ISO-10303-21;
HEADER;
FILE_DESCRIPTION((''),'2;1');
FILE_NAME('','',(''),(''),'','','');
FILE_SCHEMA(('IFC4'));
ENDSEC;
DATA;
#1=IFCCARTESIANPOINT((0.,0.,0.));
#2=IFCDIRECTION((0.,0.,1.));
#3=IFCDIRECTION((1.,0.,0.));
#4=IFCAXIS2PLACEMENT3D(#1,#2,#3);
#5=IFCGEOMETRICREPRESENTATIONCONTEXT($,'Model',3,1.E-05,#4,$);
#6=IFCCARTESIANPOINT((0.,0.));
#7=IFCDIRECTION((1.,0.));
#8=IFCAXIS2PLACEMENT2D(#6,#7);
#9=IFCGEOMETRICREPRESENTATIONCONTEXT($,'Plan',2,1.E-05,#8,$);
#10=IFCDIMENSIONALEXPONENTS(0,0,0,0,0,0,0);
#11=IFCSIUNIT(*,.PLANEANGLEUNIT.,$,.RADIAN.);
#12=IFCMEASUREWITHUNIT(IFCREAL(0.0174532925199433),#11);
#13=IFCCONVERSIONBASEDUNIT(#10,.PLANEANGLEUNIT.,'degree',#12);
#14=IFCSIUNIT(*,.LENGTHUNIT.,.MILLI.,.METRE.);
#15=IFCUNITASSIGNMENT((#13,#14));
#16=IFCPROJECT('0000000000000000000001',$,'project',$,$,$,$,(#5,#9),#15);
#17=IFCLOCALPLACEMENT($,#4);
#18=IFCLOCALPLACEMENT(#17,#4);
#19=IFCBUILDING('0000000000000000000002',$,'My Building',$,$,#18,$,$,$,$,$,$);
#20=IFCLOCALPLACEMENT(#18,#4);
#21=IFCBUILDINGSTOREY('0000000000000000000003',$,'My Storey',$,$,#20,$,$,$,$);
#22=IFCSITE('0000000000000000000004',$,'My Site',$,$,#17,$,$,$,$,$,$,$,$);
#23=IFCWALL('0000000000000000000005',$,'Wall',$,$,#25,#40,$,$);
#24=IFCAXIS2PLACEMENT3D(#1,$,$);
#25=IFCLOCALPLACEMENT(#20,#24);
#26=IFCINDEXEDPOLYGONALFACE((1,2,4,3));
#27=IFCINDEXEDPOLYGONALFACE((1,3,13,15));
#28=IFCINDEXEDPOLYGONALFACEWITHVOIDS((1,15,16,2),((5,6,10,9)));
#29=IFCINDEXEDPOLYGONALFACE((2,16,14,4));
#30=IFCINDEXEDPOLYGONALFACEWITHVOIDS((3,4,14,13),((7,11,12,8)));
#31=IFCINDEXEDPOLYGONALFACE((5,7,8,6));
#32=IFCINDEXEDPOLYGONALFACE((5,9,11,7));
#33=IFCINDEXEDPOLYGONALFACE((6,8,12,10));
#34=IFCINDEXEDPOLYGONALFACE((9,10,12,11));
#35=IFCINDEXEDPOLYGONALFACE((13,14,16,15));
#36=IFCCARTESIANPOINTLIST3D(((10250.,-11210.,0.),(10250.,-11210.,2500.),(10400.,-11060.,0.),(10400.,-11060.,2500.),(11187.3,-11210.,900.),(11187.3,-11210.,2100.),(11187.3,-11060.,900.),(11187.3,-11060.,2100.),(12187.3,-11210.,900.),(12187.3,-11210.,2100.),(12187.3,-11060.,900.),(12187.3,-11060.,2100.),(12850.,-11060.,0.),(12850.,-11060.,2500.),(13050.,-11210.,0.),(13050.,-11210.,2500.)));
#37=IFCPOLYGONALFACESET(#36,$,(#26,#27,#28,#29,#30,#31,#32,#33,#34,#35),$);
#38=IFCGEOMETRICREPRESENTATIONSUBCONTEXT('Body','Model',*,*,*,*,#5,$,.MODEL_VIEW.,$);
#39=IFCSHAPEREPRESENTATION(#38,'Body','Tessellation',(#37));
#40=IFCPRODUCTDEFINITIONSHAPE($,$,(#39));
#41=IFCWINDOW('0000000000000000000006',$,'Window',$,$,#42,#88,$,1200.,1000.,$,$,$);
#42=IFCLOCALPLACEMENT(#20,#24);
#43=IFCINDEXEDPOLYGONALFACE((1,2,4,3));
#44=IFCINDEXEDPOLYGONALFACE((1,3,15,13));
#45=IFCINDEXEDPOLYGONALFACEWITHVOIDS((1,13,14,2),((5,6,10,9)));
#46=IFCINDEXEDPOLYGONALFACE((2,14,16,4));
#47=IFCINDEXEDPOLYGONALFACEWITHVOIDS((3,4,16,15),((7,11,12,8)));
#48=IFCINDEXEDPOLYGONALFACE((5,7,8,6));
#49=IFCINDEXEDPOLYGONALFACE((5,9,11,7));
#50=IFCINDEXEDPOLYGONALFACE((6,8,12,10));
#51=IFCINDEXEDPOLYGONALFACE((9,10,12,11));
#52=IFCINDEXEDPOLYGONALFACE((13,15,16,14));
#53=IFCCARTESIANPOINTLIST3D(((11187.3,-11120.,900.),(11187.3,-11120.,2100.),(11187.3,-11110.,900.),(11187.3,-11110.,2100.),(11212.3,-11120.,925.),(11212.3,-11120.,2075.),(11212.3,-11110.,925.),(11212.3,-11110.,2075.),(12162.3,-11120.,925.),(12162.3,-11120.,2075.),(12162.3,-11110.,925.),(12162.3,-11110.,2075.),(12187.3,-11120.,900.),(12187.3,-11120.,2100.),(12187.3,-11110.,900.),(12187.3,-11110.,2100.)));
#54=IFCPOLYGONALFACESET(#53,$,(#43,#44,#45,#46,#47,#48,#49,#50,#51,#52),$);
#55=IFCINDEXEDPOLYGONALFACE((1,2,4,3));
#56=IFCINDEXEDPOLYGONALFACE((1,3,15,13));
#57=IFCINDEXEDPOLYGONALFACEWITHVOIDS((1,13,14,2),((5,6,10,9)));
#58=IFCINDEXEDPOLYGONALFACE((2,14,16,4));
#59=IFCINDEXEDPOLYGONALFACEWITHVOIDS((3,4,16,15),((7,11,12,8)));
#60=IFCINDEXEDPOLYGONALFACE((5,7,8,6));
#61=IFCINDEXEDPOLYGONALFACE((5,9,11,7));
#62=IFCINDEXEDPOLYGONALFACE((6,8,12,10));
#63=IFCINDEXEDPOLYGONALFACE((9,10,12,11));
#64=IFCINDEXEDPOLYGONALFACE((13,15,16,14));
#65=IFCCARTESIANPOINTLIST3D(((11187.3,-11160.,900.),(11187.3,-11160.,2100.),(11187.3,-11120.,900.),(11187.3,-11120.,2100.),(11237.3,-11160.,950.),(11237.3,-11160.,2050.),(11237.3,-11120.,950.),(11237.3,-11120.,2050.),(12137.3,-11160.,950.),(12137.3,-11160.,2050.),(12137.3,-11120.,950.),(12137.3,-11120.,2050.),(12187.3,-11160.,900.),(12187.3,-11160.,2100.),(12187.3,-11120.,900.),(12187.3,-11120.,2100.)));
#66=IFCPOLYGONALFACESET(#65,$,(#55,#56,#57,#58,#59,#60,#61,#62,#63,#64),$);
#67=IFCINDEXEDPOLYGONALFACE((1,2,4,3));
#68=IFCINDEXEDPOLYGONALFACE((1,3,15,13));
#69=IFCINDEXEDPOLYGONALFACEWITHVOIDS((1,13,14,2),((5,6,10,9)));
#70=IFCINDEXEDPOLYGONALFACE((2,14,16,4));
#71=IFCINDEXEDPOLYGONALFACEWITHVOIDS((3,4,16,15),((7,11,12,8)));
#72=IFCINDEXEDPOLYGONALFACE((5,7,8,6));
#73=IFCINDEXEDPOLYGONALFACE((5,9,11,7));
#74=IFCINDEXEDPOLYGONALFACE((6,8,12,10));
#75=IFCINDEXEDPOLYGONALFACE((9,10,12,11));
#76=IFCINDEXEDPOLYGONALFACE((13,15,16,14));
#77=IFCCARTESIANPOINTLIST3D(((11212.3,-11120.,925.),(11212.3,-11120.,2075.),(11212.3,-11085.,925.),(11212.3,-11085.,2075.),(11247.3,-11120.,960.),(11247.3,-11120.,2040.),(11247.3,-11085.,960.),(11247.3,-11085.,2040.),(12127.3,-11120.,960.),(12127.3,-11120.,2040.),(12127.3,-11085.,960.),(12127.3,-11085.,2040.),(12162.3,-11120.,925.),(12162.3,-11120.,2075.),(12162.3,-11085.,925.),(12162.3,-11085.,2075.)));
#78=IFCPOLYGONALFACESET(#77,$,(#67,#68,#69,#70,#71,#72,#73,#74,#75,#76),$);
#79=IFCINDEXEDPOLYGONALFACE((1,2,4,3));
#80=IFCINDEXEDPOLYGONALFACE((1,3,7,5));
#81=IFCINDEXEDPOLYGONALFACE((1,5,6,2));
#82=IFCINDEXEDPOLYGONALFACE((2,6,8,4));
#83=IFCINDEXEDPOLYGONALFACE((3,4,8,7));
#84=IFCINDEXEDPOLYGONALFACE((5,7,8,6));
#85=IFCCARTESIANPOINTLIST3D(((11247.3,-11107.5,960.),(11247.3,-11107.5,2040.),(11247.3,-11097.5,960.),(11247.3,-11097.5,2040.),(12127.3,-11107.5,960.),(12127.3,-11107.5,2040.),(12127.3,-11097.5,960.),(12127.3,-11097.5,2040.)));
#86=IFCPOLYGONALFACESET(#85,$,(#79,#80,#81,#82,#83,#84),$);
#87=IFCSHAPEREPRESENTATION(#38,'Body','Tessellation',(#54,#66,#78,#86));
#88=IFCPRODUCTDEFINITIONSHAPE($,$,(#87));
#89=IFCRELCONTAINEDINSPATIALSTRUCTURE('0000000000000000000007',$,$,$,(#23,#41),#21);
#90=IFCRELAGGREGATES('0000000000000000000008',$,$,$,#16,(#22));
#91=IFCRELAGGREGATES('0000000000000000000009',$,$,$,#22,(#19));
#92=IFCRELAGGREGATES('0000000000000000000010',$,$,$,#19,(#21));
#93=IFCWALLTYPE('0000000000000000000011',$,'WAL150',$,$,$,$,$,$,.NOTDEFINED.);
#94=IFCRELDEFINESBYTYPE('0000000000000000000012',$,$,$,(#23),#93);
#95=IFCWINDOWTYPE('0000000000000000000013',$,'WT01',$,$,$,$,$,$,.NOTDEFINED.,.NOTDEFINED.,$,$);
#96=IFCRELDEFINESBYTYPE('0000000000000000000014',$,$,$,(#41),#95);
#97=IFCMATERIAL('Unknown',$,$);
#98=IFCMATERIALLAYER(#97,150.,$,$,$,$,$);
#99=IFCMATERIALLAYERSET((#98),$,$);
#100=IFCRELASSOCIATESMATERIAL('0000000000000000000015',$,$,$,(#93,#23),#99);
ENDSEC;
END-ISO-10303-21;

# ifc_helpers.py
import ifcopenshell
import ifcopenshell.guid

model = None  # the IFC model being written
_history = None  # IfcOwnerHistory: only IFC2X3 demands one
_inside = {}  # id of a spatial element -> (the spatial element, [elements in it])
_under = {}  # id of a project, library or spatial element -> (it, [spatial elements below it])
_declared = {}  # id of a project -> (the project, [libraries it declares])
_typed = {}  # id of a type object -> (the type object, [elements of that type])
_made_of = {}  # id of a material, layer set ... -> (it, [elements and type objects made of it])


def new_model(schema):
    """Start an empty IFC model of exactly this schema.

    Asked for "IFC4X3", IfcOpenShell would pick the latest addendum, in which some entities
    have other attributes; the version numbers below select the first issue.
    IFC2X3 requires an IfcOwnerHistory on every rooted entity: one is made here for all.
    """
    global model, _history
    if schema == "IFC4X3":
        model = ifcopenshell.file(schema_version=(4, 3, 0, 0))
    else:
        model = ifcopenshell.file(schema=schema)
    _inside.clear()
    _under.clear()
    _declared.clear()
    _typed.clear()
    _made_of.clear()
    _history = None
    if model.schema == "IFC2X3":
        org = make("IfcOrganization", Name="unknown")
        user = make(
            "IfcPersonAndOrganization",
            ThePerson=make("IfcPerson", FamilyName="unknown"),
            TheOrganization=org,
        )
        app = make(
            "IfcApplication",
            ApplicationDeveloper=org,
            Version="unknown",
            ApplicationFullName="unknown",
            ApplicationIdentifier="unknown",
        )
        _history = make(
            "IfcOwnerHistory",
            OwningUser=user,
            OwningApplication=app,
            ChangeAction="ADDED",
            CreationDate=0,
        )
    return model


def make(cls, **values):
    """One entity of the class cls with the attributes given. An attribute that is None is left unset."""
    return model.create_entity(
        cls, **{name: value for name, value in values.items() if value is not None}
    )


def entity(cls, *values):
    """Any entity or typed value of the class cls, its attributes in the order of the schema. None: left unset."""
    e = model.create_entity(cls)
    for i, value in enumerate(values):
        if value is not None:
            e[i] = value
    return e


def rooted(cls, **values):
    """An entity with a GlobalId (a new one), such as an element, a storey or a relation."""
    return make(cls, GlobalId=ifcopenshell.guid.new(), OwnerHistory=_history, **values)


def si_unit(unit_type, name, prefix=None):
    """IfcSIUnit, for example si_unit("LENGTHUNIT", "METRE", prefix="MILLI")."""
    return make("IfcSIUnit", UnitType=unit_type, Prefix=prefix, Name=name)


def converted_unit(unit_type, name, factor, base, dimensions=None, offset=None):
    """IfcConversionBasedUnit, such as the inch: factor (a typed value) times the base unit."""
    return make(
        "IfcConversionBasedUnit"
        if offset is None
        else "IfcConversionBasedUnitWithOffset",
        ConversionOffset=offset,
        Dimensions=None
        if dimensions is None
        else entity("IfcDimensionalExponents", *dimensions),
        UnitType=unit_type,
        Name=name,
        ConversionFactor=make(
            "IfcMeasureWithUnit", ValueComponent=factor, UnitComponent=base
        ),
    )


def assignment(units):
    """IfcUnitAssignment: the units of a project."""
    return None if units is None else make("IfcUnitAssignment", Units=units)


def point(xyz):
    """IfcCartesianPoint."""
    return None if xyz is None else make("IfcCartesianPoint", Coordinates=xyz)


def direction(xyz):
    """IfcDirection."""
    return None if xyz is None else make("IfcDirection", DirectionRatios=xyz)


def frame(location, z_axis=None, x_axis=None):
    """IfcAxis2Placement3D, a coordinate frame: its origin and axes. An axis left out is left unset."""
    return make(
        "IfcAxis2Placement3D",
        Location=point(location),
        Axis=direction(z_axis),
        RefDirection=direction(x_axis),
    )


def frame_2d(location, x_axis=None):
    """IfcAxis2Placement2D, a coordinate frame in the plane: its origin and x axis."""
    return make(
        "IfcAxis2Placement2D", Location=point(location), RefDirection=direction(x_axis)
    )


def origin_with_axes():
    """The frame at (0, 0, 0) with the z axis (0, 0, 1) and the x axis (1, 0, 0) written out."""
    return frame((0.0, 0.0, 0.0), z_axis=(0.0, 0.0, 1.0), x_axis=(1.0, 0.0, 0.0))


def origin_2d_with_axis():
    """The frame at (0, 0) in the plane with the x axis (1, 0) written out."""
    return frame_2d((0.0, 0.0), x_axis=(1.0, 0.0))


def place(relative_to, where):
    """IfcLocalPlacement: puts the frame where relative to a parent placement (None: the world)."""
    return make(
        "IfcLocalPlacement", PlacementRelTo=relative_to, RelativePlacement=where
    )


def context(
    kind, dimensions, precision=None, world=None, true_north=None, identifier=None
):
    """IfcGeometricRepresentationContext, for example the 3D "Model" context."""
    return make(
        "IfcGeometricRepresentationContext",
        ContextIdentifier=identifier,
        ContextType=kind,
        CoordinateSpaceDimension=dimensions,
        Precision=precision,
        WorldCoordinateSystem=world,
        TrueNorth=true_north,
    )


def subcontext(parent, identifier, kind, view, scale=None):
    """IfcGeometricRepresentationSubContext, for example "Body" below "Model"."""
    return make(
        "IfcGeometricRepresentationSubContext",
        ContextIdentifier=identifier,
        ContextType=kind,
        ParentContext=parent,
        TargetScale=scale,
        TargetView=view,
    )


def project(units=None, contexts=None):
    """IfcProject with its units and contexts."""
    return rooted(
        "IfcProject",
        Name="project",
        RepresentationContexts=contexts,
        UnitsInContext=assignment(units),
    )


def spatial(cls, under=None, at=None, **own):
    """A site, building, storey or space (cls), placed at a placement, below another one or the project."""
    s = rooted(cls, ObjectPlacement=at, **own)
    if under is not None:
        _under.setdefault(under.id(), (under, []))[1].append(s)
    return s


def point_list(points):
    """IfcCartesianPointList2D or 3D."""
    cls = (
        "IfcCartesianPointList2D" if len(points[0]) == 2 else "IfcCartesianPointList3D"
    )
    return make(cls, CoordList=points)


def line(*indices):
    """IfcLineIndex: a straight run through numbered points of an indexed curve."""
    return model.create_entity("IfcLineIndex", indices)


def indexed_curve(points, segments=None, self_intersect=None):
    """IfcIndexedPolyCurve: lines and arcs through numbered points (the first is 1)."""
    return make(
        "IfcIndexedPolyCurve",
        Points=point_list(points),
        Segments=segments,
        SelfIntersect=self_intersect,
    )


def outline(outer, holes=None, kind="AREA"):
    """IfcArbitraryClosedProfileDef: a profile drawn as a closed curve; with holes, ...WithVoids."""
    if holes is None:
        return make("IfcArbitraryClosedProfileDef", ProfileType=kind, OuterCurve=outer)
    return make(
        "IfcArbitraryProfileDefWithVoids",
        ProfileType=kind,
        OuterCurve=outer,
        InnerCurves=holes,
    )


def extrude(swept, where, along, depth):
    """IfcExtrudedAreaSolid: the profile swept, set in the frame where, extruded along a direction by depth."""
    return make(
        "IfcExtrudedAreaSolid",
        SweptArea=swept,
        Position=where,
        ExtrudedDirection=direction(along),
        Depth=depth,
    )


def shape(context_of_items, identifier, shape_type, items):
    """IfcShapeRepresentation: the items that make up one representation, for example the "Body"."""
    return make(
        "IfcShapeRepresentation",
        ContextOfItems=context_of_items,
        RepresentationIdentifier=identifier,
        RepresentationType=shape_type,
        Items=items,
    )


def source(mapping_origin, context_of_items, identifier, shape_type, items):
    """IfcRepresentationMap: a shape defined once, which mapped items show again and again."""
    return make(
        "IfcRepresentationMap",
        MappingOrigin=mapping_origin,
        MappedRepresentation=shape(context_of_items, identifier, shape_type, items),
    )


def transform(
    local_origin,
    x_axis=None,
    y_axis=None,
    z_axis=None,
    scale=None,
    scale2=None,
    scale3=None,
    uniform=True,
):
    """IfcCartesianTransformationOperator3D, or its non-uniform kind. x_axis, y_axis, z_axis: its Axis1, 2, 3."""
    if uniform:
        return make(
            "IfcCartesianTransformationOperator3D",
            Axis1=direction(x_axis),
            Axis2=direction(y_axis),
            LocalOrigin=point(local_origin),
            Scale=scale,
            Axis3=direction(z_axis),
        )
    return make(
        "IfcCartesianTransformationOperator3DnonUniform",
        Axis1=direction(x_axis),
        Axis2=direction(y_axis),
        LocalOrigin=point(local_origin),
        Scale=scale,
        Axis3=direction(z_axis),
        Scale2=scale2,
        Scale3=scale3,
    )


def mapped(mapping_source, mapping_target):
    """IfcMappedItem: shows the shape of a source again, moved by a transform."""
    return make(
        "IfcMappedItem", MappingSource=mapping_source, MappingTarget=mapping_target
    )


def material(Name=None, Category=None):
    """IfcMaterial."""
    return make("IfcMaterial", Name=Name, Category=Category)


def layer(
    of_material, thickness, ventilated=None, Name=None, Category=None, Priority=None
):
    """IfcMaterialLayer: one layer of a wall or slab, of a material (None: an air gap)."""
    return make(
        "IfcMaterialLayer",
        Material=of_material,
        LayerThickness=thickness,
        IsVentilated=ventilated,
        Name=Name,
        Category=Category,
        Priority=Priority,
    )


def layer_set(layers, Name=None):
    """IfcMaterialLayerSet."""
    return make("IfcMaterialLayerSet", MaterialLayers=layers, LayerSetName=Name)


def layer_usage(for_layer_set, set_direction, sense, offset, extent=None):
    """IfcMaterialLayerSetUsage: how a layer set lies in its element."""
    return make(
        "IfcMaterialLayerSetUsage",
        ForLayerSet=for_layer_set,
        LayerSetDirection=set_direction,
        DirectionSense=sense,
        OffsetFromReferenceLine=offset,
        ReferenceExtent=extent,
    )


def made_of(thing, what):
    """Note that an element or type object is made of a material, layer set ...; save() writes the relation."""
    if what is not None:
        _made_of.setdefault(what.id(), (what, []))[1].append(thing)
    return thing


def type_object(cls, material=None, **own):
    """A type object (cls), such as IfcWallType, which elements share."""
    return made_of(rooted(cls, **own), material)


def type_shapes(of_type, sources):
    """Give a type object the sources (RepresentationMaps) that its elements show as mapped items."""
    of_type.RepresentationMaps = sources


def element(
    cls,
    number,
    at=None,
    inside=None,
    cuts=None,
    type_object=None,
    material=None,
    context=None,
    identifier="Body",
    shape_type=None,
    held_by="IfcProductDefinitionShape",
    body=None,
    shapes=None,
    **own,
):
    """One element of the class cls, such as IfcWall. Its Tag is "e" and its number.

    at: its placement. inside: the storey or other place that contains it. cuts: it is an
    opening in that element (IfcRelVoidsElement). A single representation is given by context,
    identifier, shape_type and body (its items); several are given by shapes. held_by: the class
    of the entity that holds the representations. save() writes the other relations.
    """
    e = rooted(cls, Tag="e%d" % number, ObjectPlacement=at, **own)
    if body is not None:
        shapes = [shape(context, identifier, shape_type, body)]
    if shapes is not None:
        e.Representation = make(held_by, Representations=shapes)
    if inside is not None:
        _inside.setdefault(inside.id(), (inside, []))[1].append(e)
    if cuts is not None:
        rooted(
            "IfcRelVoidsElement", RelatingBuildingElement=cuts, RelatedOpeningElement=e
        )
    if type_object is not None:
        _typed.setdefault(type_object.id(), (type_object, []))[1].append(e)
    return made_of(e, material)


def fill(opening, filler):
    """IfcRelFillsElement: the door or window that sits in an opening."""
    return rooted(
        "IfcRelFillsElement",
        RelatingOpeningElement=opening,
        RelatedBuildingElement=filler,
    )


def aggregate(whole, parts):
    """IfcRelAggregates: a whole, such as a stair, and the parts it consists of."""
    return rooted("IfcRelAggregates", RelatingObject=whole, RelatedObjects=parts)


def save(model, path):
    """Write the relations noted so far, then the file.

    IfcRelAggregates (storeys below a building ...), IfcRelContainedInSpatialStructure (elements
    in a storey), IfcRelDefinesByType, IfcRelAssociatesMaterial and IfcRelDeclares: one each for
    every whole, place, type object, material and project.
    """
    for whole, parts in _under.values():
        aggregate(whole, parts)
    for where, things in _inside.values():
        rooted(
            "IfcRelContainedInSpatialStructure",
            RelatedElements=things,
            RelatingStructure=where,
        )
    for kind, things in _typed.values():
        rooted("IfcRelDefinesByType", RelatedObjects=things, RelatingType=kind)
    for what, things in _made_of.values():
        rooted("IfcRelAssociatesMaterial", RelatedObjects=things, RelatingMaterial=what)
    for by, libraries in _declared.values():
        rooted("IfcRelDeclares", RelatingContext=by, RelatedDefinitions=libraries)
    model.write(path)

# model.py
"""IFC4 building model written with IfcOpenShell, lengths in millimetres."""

from ifc_helpers import new_model, entity, si_unit, converted_unit, frame, origin_with_axes, origin_2d_with_axis, place, context, subcontext, project, spatial, line, indexed_curve, outline, extrude, shape, source, transform, mapped, material, layer, layer_set, layer_usage, type_object, type_shapes, element, fill, save


model = new_model("IFC4")

# Units and contexts
model_context = context("Model", 3, precision=1e-05, world=origin_with_axes())
plan_context = context("Plan", 2, precision=1e-05, world=origin_2d_with_axis())
body_context_1 = subcontext(model_context, "Body", "Model", "MODEL_VIEW")
body_context_2 = subcontext(plan_context, "Body", "Plan", "PLAN_VIEW")
ifc_project = project(units=[converted_unit("PLANEANGLEUNIT", "degree", entity("IfcReal", 0.0174532925199433), si_unit("PLANEANGLEUNIT", "RADIAN"), dimensions=[0, 0, 0, 0, 0, 0, 0]), si_unit("LENGTHUNIT", "METRE", prefix="MILLI")], contexts=[model_context, plan_context])

# Site, building, storey
site_placement = place(None, origin_with_axes())
site = spatial("IfcSite", under=ifc_project, at=site_placement, Name="My Site")
building_placement = place(site_placement, origin_with_axes())
building = spatial("IfcBuilding", under=site, at=building_placement, Name="My Building")
storey_placement = place(building_placement, origin_with_axes())
storey = spatial("IfcBuildingStorey", under=building, at=storey_placement, Name="My Storey")

# Shared definitions
ifc_material = material(Name="Unknown")

# Shared definitions
ifc_layer_1 = layer(ifc_material, 150.0)
ifc_layer_set_1 = layer_set([ifc_layer_1])
wall_type_1 = type_object("IfcWallType", Name="WAL150", PredefinedType="NOTDEFINED", material=ifc_layer_set_1)

# Wall, opening, window
ifc_layer_usage_1 = layer_usage(ifc_layer_set_1, "AXIS2", "POSITIVE", 0.0)
wall_1_placement = place(storey_placement, frame((10250.0, -11210.0, 0.0), z_axis=(0.0, 0.0, 1.0), x_axis=(1.0, 0.0, 0.0)))
wall_1 = element("IfcWall", 1, at=wall_1_placement, inside=storey, type_object=wall_type_1, material=ifc_layer_usage_1, Name="Wall", context=body_context_1, shape_type="SweptSolid", body=[
    extrude(outline(indexed_curve([(0.0, 0.0), (150.0, 150.0), (2600.0, 150.0), (2800.0, 0.0)], segments=[line(1, 2, 3, 4, 1)])), origin_with_axes(), (0.0, 0.0, 1.0), 2500.0),
])
shared_shape_1 = source(origin_with_axes(), body_context_1, "Body", "SweptSolid", [
    extrude(outline(indexed_curve([(0.0, 0.0), (1000.0, 0.0), (1000.0, 1200.0), (0.0, 1200.0)], segments=[line(1, 2, 3, 4, 1)])), frame((0.0, -600.0, 0.0), z_axis=(0.0, -1.0, 0.0), x_axis=(1.0, 0.0, 0.0)), (0.0, 0.0, -1.0), 1200.0),
])
opening_placement = place(wall_1_placement, frame((937.3, 0.0, 900.0), z_axis=(0.0, 0.0, 1.0), x_axis=(1.0, 0.0, 0.0)))
opening = element("IfcOpeningElement", 2, at=opening_placement, cuts=wall_1, PredefinedType="OPENING", context=body_context_1, shape_type="MappedRepresentation", body=[
    mapped(shared_shape_1, transform((0.0, 0.0, 0.0), x_axis=(1.0, 0.0, 0.0), y_axis=(0.0, 1.0, 0.0), z_axis=(0.0, 0.0, 1.0), scale=1.0)),
])
window_type = type_object("IfcWindowType", Name="WT01", PartitioningType="NOTDEFINED", PredefinedType="NOTDEFINED")
shared_shape_2 = source(origin_with_axes(), body_context_1, "Body", "SweptSolid", [
    extrude(outline(indexed_curve([(0.0, 0.0), (1000.0, 0.0), (1000.0, 1200.0), (0.0, 1200.0)], segments=[line(1, 2, 3, 4, 1)]), holes=[indexed_curve([(25.0, 25.0), (975.0, 25.0), (975.0, 1175.0), (25.0, 1175.0)], segments=[line(1, 2, 3, 4, 1)])]), frame((0.0, 90.0, 0.0), z_axis=(0.0, -1.0, 0.0), x_axis=(1.0, 0.0, 0.0)), (0.0, 0.0, -1.0), 10.0),
    extrude(outline(indexed_curve([(0.0, 0.0), (1000.0, 0.0), (1000.0, 1200.0), (0.0, 1200.0)], segments=[line(1, 2, 3, 4, 1)]), holes=[indexed_curve([(50.0, 50.0), (950.0, 50.0), (950.0, 1150.0), (50.0, 1150.0)], segments=[line(1, 2, 3, 4, 1)])]), frame((0.0, 50.0, 0.0), z_axis=(0.0, -1.0, 0.0), x_axis=(1.0, 0.0, 0.0)), (0.0, 0.0, -1.0), 40.0),
    extrude(outline(indexed_curve([(0.0, 0.0), (950.0, 0.0), (950.0, 1150.0), (0.0, 1150.0)], segments=[line(1, 2, 3, 4, 1)]), holes=[indexed_curve([(35.0, 35.0), (915.0, 35.0), (915.0, 1115.0), (35.0, 1115.0)], segments=[line(1, 2, 3, 4, 1)])]), frame((25.0, 90.0, 25.0), z_axis=(0.0, -1.0, 0.0), x_axis=(1.0, 0.0, 0.0)), (0.0, 0.0, -1.0), 35.0),
    extrude(outline(indexed_curve([(35.0, 35.0), (915.0, 35.0), (915.0, 1115.0), (35.0, 1115.0)], segments=[line(1, 2, 3, 4, 1)])), frame((25.0, 102.5, 25.0), z_axis=(0.0, -1.0, 0.0), x_axis=(1.0, 0.0, 0.0)), (0.0, 0.0, -1.0), 10.0),
])
shared_shape_3 = source(origin_with_axes(), body_context_2, "Body", "Curve2D", [
    entity("IfcIndexedPolyCurve", entity("IfcCartesianPointList2D", [[50.0, 50.0], [950.0, 50.0]])),
    entity("IfcIndexedPolyCurve", entity("IfcCartesianPointList2D", [[0.0, 100.0], [25.0, 100.0], [25.0, 90.0], [50.0, 90.0], [50.0, 50.0], [0.0, 50.0]]), [entity("IfcLineIndex", [1, 2, 3, 4, 5, 6, 1])]),
    entity("IfcIndexedPolyCurve", entity("IfcCartesianPointList2D", [[1000.0, 100.0], [975.0, 100.0], [975.0, 90.0], [950.0, 90.0], [950.0, 50.0], [1000.0, 50.0]]), [entity("IfcLineIndex", [1, 2, 3, 4, 5, 6, 1])]),
    entity("IfcIndexedPolyCurve", entity("IfcCartesianPointList2D", [[25.0, 90.0], [60.0, 90.0], [60.0, 125.0], [25.0, 125.0]]), [entity("IfcLineIndex", [1, 2, 3, 4, 1])]),
    entity("IfcIndexedPolyCurve", entity("IfcCartesianPointList2D", [[975.0, 90.0], [940.0, 90.0], [940.0, 125.0], [975.0, 125.0]]), [entity("IfcLineIndex", [1, 2, 3, 4, 1])]),
    entity("IfcIndexedPolyCurve", entity("IfcCartesianPointList2D", [[60.0, 90.0], [940.0, 90.0]])),
    entity("IfcIndexedPolyCurve", entity("IfcCartesianPointList2D", [[60.0, 125.0], [940.0, 125.0]])),
    entity("IfcIndexedPolyCurve", entity("IfcCartesianPointList2D", [[60.0, 107.5], [940.0, 107.5]])),
])
type_shapes(window_type, [shared_shape_2, shared_shape_3])
window_placement = place(opening_placement, origin_with_axes())
window = element("IfcWindow", 3, at=window_placement, inside=storey, type_object=window_type, Name="Window", OverallHeight=1200.0, OverallWidth=1000.0, shapes=[
    shape(body_context_1, "Body", "MappedRepresentation", [mapped(shared_shape_2, transform((0.0, 0.0, 0.0), x_axis=(1.0, 0.0, 0.0), y_axis=(0.0, 1.0, 0.0), z_axis=(0.0, 0.0, 1.0), scale=1.0))]),
    shape(body_context_2, "Body", "MappedRepresentation", [mapped(shared_shape_3, transform((0.0, 0.0, 0.0), x_axis=(1.0, 0.0, 0.0), y_axis=(0.0, 1.0, 0.0), z_axis=(0.0, 0.0, 1.0), scale=1.0))]),
])
fill(opening, window)

save(model, "model.ifc")
